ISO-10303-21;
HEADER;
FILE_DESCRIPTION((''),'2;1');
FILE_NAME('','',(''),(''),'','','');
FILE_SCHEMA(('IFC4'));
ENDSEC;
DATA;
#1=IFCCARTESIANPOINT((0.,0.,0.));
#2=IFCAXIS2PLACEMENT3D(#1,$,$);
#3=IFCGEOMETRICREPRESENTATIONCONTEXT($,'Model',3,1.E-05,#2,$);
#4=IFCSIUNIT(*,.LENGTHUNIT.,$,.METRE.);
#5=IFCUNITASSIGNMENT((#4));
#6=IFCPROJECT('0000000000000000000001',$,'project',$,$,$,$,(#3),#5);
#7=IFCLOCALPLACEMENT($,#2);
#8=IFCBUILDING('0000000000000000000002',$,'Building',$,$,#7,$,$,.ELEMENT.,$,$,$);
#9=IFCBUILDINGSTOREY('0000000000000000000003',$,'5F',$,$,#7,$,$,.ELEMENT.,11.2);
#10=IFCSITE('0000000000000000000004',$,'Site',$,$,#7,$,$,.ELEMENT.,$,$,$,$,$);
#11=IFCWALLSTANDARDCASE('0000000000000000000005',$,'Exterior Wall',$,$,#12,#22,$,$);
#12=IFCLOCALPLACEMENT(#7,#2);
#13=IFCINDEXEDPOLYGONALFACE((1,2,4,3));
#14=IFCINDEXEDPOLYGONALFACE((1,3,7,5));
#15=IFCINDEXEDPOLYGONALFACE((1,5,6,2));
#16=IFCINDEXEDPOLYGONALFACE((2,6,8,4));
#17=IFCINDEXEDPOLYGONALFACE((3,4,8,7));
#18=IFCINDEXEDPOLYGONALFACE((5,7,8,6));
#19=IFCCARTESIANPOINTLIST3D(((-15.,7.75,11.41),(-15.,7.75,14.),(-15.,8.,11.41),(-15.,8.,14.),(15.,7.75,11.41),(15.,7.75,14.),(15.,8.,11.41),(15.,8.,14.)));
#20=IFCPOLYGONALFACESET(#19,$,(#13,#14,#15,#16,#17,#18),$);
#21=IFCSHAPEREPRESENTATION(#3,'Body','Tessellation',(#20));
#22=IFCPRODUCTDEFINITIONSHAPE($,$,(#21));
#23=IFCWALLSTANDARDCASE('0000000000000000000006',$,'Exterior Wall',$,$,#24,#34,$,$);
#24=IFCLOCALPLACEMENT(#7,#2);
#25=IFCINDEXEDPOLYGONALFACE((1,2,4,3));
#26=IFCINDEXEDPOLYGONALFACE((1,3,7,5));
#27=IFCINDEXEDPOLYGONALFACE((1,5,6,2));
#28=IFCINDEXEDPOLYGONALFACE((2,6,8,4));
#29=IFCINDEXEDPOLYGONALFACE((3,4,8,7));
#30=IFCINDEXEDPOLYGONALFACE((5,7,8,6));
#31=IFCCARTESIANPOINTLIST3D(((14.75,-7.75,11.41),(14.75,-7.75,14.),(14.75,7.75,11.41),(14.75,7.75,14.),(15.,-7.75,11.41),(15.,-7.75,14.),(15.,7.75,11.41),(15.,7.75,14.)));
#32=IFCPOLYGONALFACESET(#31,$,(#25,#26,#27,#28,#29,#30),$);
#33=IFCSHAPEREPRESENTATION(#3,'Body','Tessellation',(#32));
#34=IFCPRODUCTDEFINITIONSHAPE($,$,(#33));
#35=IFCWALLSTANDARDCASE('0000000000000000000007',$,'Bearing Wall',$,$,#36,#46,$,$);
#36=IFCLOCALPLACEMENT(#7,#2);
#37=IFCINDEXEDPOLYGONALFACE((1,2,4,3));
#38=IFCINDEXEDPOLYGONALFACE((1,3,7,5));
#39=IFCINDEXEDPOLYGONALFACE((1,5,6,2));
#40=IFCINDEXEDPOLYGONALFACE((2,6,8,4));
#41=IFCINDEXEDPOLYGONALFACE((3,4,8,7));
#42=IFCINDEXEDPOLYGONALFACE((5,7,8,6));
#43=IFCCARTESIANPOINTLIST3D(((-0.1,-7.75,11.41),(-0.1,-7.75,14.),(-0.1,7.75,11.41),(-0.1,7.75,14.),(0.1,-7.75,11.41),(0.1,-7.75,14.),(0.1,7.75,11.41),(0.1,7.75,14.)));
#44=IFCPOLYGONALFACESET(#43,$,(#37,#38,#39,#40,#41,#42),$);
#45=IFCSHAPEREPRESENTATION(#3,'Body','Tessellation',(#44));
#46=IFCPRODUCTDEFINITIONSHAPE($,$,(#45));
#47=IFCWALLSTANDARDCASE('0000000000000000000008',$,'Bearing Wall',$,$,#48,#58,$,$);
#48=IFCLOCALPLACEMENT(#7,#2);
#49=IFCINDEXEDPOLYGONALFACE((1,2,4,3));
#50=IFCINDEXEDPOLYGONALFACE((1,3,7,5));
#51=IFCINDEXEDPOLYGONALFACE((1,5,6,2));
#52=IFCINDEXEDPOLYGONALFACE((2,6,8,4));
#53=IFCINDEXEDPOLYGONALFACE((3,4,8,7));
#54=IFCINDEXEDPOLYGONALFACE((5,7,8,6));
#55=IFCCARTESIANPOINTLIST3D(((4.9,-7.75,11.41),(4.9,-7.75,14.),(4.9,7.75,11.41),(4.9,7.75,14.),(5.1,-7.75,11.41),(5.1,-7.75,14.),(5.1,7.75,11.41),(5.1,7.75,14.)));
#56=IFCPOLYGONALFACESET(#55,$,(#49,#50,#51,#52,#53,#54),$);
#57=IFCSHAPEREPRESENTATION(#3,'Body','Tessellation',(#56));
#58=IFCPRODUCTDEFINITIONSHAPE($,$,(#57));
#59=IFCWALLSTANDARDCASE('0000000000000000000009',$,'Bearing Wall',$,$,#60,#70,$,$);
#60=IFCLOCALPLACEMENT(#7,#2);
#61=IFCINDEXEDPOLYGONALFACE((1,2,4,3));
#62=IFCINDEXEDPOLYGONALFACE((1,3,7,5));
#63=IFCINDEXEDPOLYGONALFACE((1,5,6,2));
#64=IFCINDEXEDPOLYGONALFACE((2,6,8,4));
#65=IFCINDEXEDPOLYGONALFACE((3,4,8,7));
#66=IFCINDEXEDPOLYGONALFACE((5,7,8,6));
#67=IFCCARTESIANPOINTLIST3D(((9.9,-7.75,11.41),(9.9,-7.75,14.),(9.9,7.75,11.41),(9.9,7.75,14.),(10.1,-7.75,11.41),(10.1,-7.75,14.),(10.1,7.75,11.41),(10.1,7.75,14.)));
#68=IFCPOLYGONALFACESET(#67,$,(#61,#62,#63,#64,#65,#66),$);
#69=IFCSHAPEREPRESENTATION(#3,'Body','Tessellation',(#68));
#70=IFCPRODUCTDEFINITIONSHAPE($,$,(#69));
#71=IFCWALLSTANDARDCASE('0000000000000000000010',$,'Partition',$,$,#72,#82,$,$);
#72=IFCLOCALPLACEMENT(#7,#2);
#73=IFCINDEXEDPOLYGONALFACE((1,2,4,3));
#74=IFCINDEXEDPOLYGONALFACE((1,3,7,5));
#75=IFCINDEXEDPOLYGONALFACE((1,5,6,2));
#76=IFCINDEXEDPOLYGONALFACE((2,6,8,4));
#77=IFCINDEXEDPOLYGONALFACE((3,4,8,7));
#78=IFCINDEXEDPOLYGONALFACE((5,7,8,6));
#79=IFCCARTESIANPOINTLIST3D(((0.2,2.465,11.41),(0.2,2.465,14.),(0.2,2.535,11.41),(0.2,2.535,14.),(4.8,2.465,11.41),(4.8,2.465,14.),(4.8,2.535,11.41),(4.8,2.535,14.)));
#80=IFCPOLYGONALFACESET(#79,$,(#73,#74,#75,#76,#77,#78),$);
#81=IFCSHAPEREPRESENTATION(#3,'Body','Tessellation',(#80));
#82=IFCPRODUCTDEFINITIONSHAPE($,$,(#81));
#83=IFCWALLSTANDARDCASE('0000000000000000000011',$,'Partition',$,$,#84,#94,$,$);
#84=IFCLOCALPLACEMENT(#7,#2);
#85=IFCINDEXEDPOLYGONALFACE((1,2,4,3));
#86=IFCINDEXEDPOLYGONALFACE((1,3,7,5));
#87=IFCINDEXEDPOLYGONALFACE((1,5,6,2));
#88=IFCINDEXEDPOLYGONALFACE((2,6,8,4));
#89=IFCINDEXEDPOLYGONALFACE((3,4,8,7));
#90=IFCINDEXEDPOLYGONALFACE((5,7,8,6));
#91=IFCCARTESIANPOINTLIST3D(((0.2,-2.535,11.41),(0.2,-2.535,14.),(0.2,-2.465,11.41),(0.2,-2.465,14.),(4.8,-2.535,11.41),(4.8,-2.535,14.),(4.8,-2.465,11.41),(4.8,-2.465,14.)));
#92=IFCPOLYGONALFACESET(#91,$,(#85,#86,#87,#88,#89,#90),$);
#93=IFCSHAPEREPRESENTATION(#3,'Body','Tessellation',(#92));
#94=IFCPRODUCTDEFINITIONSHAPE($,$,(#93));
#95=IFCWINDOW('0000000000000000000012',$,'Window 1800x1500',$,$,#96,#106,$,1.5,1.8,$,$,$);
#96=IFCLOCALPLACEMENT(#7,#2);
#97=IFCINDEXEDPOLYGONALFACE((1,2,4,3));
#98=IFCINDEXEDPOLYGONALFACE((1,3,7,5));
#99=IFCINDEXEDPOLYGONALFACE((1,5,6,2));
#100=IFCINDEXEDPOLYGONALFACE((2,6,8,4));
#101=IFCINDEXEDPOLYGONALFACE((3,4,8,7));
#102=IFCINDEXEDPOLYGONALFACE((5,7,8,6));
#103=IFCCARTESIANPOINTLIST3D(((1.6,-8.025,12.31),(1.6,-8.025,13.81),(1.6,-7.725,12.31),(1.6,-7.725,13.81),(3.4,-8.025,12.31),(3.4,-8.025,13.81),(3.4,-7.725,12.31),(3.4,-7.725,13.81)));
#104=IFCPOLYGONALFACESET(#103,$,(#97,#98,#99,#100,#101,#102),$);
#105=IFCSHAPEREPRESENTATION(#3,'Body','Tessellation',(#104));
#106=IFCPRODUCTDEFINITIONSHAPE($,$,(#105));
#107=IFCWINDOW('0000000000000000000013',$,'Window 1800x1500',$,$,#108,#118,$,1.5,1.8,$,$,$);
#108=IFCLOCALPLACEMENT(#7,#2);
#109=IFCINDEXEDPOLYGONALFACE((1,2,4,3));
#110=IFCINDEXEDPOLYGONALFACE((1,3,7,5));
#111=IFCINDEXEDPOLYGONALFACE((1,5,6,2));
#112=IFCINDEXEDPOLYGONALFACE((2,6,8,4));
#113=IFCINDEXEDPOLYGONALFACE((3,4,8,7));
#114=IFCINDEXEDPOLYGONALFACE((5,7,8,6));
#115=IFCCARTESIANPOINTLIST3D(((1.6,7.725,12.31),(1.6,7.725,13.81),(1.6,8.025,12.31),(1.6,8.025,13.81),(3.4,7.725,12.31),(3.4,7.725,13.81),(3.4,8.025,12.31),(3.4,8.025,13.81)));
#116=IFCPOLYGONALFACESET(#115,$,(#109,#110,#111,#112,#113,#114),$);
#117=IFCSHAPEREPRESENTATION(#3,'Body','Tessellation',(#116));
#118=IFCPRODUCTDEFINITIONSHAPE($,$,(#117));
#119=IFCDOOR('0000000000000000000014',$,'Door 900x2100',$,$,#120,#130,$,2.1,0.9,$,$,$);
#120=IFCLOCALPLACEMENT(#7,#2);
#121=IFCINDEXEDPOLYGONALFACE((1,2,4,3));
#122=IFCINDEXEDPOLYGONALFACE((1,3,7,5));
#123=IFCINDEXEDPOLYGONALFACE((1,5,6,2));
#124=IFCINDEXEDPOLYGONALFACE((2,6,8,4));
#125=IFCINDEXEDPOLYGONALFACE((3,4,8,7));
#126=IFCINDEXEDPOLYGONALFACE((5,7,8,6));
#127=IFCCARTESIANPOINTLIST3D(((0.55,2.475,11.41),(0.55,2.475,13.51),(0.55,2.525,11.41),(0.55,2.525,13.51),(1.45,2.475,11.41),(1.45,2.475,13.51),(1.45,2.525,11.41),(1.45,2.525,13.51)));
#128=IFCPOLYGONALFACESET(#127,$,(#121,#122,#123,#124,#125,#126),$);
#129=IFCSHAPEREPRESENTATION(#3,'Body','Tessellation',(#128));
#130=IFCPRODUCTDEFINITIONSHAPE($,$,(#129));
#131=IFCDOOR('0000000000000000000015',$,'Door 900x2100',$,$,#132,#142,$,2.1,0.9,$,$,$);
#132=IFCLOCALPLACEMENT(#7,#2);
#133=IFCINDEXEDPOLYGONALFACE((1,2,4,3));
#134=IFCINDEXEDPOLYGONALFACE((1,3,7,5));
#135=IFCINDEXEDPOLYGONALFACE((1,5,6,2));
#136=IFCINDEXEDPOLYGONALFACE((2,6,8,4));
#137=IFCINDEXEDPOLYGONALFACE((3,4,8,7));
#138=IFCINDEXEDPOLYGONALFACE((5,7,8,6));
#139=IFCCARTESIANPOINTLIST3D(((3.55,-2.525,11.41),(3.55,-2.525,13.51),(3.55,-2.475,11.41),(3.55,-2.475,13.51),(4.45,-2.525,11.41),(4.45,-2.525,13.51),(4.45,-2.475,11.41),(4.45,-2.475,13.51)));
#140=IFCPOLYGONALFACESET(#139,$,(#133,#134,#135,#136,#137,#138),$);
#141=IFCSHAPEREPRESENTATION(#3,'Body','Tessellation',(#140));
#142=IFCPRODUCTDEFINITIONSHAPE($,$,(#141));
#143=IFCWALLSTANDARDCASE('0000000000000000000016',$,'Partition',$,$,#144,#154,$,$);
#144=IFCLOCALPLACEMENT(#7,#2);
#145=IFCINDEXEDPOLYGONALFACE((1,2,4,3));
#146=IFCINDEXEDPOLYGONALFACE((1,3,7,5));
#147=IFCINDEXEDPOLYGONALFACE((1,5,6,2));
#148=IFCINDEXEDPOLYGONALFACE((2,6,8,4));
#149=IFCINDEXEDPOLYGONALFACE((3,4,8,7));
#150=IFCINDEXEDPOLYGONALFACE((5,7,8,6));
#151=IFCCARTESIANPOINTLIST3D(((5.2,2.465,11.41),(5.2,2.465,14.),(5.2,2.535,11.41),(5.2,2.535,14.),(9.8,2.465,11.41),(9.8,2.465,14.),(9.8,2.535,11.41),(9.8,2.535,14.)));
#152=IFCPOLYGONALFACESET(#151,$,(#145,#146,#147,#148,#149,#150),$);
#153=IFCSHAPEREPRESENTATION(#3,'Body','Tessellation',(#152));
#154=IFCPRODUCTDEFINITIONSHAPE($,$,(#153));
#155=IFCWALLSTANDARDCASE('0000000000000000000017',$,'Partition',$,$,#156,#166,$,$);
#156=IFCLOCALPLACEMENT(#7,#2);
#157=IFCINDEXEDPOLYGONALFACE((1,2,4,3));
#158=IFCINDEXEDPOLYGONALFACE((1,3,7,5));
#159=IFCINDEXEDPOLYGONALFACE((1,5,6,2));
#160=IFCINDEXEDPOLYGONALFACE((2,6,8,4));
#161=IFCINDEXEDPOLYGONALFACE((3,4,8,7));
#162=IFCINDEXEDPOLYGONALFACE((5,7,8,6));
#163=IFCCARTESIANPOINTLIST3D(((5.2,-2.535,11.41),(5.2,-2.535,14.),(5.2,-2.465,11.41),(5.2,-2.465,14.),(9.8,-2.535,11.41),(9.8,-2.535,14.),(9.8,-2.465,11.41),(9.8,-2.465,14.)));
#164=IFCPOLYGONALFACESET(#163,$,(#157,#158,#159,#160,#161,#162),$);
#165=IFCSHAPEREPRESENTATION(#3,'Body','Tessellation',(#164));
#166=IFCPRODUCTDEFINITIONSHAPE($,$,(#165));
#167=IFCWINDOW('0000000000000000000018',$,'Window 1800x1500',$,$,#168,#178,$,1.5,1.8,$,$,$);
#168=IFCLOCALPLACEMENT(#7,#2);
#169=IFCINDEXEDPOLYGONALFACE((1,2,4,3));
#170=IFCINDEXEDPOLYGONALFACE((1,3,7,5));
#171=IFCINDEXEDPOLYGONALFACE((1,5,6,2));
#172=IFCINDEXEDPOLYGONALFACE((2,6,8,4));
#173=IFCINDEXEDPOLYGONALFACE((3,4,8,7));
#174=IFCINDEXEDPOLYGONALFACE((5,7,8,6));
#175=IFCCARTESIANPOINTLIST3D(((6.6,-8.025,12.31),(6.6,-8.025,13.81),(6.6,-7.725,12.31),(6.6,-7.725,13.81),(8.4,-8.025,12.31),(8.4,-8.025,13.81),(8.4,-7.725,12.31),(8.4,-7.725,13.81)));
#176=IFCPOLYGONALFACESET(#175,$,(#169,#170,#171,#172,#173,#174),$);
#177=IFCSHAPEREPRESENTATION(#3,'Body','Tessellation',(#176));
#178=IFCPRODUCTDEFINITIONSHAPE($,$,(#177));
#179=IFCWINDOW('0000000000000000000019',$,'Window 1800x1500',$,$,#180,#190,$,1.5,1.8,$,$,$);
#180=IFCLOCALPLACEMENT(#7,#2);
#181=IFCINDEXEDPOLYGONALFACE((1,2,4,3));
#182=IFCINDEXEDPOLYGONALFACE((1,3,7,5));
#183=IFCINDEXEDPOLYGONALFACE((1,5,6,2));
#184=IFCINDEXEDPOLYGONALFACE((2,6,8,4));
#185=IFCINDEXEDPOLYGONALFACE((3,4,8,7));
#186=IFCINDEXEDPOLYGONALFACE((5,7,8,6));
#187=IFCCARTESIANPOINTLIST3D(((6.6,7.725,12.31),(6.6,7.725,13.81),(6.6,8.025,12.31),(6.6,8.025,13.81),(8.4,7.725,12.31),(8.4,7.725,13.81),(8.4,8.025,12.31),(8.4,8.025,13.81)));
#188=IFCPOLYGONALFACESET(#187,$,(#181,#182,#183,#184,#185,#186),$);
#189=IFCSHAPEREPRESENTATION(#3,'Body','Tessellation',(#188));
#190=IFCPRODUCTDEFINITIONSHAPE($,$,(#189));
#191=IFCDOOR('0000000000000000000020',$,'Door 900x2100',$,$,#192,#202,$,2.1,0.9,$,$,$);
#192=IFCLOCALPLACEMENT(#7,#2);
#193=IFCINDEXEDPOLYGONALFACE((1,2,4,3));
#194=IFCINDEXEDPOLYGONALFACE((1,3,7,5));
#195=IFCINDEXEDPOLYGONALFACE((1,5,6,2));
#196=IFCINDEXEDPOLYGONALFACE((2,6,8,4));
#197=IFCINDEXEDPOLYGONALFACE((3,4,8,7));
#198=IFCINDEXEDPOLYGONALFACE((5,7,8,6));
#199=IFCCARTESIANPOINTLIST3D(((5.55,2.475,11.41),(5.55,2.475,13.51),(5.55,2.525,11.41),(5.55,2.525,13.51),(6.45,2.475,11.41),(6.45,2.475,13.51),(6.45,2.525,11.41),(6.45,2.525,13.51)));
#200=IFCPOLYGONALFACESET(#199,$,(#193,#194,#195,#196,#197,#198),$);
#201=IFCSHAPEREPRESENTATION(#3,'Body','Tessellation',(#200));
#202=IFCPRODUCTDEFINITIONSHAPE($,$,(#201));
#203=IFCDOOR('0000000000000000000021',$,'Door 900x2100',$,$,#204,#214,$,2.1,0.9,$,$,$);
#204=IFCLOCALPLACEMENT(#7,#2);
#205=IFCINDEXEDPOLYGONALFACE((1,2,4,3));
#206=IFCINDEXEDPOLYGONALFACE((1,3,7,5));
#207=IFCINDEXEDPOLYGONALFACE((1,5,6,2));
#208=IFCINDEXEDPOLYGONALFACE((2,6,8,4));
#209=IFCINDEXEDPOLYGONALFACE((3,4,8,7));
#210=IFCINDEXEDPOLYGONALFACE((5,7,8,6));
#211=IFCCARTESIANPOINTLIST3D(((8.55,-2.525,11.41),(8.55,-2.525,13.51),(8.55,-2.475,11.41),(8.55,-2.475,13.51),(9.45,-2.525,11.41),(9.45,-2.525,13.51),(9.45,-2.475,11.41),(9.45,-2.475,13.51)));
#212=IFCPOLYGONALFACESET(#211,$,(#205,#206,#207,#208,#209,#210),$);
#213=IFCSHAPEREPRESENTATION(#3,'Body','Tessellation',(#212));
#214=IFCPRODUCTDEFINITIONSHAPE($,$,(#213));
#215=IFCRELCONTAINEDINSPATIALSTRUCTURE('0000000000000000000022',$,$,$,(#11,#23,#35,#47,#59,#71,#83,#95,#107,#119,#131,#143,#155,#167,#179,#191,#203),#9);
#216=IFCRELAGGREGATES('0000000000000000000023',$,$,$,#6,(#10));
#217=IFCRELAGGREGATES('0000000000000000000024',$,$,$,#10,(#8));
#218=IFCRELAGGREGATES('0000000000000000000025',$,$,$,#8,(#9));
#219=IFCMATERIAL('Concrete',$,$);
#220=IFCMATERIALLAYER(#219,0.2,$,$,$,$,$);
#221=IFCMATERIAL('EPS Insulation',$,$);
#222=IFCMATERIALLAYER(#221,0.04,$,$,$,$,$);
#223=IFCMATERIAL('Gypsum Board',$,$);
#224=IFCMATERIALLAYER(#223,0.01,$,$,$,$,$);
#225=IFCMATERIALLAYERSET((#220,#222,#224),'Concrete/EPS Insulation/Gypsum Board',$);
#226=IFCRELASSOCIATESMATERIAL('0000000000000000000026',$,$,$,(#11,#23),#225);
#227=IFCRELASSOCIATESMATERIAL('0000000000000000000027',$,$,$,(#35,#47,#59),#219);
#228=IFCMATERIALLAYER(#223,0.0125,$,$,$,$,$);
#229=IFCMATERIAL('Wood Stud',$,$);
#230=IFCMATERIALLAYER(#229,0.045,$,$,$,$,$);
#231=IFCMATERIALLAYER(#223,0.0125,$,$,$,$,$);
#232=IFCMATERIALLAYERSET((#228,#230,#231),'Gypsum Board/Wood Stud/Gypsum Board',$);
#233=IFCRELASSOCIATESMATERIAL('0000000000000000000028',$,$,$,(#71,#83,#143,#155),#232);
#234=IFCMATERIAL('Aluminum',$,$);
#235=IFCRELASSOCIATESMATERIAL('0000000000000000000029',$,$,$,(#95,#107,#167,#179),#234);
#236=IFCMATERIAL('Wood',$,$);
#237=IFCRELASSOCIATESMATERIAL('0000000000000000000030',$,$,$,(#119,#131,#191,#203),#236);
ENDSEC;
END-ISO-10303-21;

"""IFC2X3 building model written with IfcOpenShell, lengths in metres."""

from ifc_helpers import new_model, si_unit, frame, origin, origin_2d, place, context, project, spatial, rectangle, extrude, material, layer, layer_set, layer_usage, element, save


model = new_model("IFC2X3")

# Units and contexts
model_context = context("Model", 3, precision=1e-05, world=origin())
ifc_project = project(units=[si_unit("LENGTHUNIT", "METRE")], contexts=[model_context])

# Site, building, storey
placement = place(None, origin())
site = spatial("IfcSite", under=ifc_project, at=placement, Name="Site", CompositionType="ELEMENT")
building = spatial("IfcBuilding", under=site, at=placement, Name="Building", CompositionType="ELEMENT")
storey = spatial("IfcBuildingStorey", under=building, at=placement, Name="5F", CompositionType="ELEMENT", Elevation=11.2)

# Walls
ifc_material_1 = material(Name="Concrete")
ifc_layer_1 = layer(ifc_material_1, 0.2)
ifc_material_2 = material(Name="EPS Insulation")
ifc_layer_2 = layer(ifc_material_2, 0.04)
ifc_material_3 = material(Name="Gypsum Board")
ifc_layer_3 = layer(ifc_material_3, 0.01)
ifc_layer_set_1 = layer_set([ifc_layer_1, ifc_layer_2, ifc_layer_3], Name="Concrete/EPS Insulation/Gypsum Board")
ifc_layer_usage_1 = layer_usage(ifc_layer_set_1, "AXIS2", "POSITIVE", 0.0)
wall_1_placement = place(None, frame((0.0, 7.875, 11.41)))
element("IfcWallStandardCase", 1, at=wall_1_placement, inside=storey, material=ifc_layer_usage_1, Name="Exterior Wall", context=model_context, shape_type="SweptSolid", body=[
    extrude(rectangle(XDim=30.0, YDim=0.25, at=origin_2d()), origin(), (0.0, 0.0, 1.0), 2.59),
])
wall_2_placement = place(None, frame((14.875, 0.0, 11.41)))
element("IfcWallStandardCase", 2, at=wall_2_placement, inside=storey, material=ifc_layer_usage_1, Name="Exterior Wall", context=model_context, shape_type="SweptSolid", body=[
    extrude(rectangle(XDim=0.25, YDim=15.5, at=origin_2d()), origin(), (0.0, 0.0, 1.0), 2.59),
])
for number, where, name in (
    (3, (0.0, 0.0, 11.41), "Bearing Wall"),
    (4, (5.0, 0.0, 11.41), "Bearing Wall"),
    (5, (10.0, 0.0, 11.41), "Bearing Wall"),
):
    element("IfcWallStandardCase", number, at=place(None, frame(where)), inside=storey, material=ifc_material_1, Name=name, context=model_context, shape_type="SweptSolid", body=[
        extrude(rectangle(XDim=0.2, YDim=15.5, at=origin_2d()), origin(), (0.0, 0.0, 1.0), 2.59),
    ])
ifc_layer_4 = layer(ifc_material_3, 0.0125)
ifc_material_4 = material(Name="Wood Stud")
ifc_layer_5 = layer(ifc_material_4, 0.045)
ifc_layer_6 = layer(ifc_material_3, 0.0125)
ifc_layer_set_2 = layer_set([ifc_layer_4, ifc_layer_5, ifc_layer_6], Name="Gypsum Board/Wood Stud/Gypsum Board")
ifc_layer_usage_2 = layer_usage(ifc_layer_set_2, "AXIS2", "POSITIVE", 0.0)
for number, where, name in (
    (6, (2.5, 2.5, 11.41), "Partition"),
    (7, (2.5, -2.5, 11.41), "Partition"),
):
    element("IfcWallStandardCase", number, at=place(None, frame(where)), inside=storey, material=ifc_layer_usage_2, Name=name, context=model_context, shape_type="SweptSolid", body=[
        extrude(rectangle(XDim=4.6, YDim=0.07, at=origin_2d()), origin(), (0.0, 0.0, 1.0), 2.59),
    ])

# Windows
ifc_material_5 = material(Name="Aluminum")
for number, where, name in (
    (8, (2.5, -7.875, 12.31), "Window 1800x1500"),
    (9, (2.5, 7.875, 12.31), "Window 1800x1500"),
):
    element("IfcWindow", number, at=place(None, frame(where)), inside=storey, material=ifc_material_5, Name=name, OverallHeight=1.5, OverallWidth=1.8, context=model_context, shape_type="SweptSolid", body=[
        extrude(rectangle(XDim=1.8, YDim=0.3, at=origin_2d()), origin(), (0.0, 0.0, 1.0), 1.5),
    ])

# Doors
ifc_material_6 = material(Name="Wood")
for number, where, name in (
    (10, (1.0, 2.5, 11.41), "Door 900x2100"),
    (11, (4.0, -2.5, 11.41), "Door 900x2100"),
):
    element("IfcDoor", number, at=place(None, frame(where)), inside=storey, material=ifc_material_6, Name=name, OverallHeight=2.1, OverallWidth=0.9, context=model_context, shape_type="SweptSolid", body=[
        extrude(rectangle(XDim=0.9, YDim=0.05, at=origin_2d()), origin(), (0.0, 0.0, 1.0), 2.1),
    ])

# Walls
for number, where, name in (
    (12, (7.5, 2.5, 11.41), "Partition"),
    (13, (7.5, -2.5, 11.41), "Partition"),
):
    element("IfcWallStandardCase", number, at=place(None, frame(where)), inside=storey, material=ifc_layer_usage_2, Name=name, context=model_context, shape_type="SweptSolid", body=[
        extrude(rectangle(XDim=4.6, YDim=0.07, at=origin_2d()), origin(), (0.0, 0.0, 1.0), 2.59),
    ])

# Windows
for number, where, name in (
    (14, (7.5, -7.875, 12.31), "Window 1800x1500"),
    (15, (7.5, 7.875, 12.31), "Window 1800x1500"),
):
    element("IfcWindow", number, at=place(None, frame(where)), inside=storey, material=ifc_material_5, Name=name, OverallHeight=1.5, OverallWidth=1.8, context=model_context, shape_type="SweptSolid", body=[
        extrude(rectangle(XDim=1.8, YDim=0.3, at=origin_2d()), origin(), (0.0, 0.0, 1.0), 1.5),
    ])

# Doors
for number, where, name in (
    (16, (6.0, 2.5, 11.41), "Door 900x2100"),
    (17, (9.0, -2.5, 11.41), "Door 900x2100"),
):
    element("IfcDoor", number, at=place(None, frame(where)), inside=storey, material=ifc_material_6, Name=name, OverallHeight=2.1, OverallWidth=0.9, context=model_context, shape_type="SweptSolid", body=[
        extrude(rectangle(XDim=0.9, YDim=0.05, at=origin_2d()), origin(), (0.0, 0.0, 1.0), 2.1),
    ])

save(model, "model.ifc")
